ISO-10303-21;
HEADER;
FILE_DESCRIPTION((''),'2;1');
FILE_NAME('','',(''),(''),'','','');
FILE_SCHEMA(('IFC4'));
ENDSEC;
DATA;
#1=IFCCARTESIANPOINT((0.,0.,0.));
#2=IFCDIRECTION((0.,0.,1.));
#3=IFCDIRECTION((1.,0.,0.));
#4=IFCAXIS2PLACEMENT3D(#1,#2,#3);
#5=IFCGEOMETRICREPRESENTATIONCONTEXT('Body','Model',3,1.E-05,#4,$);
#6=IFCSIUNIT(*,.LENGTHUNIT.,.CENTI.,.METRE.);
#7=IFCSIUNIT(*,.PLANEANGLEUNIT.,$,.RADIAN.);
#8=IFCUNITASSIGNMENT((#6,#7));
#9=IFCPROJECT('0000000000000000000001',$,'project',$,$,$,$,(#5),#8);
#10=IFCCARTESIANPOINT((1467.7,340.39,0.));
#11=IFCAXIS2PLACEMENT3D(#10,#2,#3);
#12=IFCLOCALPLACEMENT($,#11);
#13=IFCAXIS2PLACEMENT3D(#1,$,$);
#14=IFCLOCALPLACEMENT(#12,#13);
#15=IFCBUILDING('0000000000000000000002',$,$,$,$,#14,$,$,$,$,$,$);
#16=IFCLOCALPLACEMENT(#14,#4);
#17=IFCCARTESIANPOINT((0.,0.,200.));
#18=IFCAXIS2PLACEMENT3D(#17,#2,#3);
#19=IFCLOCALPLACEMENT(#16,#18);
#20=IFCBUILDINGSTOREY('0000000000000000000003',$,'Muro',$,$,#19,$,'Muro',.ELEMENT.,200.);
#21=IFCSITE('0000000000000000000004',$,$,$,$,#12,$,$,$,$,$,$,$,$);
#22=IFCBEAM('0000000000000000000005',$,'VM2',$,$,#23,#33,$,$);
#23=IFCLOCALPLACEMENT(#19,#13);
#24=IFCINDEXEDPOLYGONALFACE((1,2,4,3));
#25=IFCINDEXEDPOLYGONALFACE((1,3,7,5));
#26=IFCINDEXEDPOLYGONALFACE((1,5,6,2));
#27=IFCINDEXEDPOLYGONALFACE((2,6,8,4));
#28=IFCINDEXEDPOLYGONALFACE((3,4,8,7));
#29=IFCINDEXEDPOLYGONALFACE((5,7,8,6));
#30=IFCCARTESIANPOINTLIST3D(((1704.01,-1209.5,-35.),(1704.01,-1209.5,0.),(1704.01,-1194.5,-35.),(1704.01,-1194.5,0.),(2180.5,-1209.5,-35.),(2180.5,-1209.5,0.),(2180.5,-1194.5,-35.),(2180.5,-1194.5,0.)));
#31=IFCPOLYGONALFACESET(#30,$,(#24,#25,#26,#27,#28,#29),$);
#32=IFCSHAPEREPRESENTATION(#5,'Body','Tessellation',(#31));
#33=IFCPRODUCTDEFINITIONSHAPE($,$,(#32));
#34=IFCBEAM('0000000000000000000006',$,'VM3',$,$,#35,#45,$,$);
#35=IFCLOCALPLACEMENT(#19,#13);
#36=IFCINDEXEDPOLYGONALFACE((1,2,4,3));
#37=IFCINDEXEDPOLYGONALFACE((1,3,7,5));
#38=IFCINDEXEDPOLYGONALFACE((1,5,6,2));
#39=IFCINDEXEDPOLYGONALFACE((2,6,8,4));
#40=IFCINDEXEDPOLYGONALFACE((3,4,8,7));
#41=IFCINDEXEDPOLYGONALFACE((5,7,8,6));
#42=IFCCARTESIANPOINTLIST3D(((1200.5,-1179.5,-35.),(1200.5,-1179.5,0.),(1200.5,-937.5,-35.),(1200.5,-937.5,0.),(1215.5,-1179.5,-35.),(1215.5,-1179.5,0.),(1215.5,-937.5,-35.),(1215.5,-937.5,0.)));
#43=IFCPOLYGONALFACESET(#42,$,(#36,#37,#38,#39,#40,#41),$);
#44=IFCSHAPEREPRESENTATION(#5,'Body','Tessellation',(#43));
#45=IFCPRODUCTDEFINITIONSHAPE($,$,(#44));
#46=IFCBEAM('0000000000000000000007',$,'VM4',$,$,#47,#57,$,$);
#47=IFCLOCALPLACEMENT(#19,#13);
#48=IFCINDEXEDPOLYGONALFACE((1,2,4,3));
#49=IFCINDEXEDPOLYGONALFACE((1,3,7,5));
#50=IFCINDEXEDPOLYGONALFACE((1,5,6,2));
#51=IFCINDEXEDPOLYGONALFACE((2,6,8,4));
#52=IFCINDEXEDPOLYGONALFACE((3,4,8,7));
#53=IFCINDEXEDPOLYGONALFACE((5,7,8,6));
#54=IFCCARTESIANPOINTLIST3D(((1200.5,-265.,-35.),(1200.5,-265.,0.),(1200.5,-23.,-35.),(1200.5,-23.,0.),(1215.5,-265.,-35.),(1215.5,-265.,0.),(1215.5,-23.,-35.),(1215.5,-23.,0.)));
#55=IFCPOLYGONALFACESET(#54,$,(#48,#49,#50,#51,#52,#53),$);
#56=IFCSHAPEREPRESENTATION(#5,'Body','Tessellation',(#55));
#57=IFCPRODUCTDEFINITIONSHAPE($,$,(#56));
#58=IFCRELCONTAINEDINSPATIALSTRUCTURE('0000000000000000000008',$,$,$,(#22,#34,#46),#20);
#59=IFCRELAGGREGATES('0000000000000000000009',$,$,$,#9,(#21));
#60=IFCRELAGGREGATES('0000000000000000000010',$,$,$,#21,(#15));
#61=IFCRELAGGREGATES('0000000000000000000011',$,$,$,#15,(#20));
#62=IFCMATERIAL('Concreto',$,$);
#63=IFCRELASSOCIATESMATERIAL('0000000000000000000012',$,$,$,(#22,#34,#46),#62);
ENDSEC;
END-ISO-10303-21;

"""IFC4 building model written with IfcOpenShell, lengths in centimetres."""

from ifc_helpers import new_model, si_unit, frame, origin, origin_with_axes, origin_2d_with_axis, place, context, project, spatial, rectangle, extrude, material, element, save


model = new_model("IFC4")

# Units and contexts
model_context = context("Model", 3, precision=1e-05, world=origin_with_axes(), identifier="Body")
ifc_project = project(units=[si_unit("LENGTHUNIT", "METRE", prefix="CENTI"), si_unit("PLANEANGLEUNIT", "RADIAN")], contexts=[model_context])

# Site, building, storey
site_placement = place(None, frame((1467.7, 340.39, 0.0), z_axis=(0.0, 0.0, 1.0), x_axis=(1.0, 0.0, 0.0)))
site = spatial("IfcSite", under=ifc_project, at=site_placement)
building_placement = place(site_placement, origin())
building = spatial("IfcBuilding", under=site, at=building_placement)
placement = place(building_placement, origin_with_axes())
storey_placement = place(placement, frame((0.0, 0.0, 200.0), z_axis=(0.0, 0.0, 1.0), x_axis=(1.0, 0.0, 0.0)))
storey = spatial("IfcBuildingStorey", under=building, at=storey_placement, Name="Muro", LongName="Muro", CompositionType="ELEMENT", Elevation=200.0)

# Shared definitions
ifc_material = material(Name="Concreto")

# Beams
beam_1_placement = place(storey_placement, frame((1942.26, -1202.0, 0.0), z_axis=(0.0, 0.0, 1.0), x_axis=(1.0, 0.0, 0.0)))
element("IfcBeam", 1, at=beam_1_placement, inside=storey, material=ifc_material, Name="VM2", context=model_context, shape_type="SolidModel", body=[
    extrude(rectangle(XDim=15.0, YDim=35.0, at=origin_2d_with_axis()), frame((-238.25, 0.0, -17.5), z_axis=(1.0, 0.0, 0.0), x_axis=(0.0, -1.0, 0.0)), (0.0, 0.0, 1.0), 476.49),
])
for number, where, z_axis, x_axis, name in (
    (2, (1208.0, -1058.5, 0.0), (0.0, 0.0, 1.0), (1.0, 0.0, 0.0), "VM3"),
    (3, (1208.0, -144.0, 0.0), (0.0, 0.0, 1.0), (1.0, 0.0, 0.0), "VM4"),
):
    element("IfcBeam", number, at=place(storey_placement, frame(where, z_axis=z_axis, x_axis=x_axis)), inside=storey, material=ifc_material, Name=name, context=model_context, shape_type="SolidModel", body=[
        extrude(rectangle(XDim=15.0, YDim=35.0, at=origin_2d_with_axis()), frame((0.0, -121.0, -17.5), z_axis=(0.0, 1.0, 0.0), x_axis=(1.0, 0.0, 0.0)), (0.0, 0.0, 1.0), 242.0),
    ])

save(model, "model.ifc")
